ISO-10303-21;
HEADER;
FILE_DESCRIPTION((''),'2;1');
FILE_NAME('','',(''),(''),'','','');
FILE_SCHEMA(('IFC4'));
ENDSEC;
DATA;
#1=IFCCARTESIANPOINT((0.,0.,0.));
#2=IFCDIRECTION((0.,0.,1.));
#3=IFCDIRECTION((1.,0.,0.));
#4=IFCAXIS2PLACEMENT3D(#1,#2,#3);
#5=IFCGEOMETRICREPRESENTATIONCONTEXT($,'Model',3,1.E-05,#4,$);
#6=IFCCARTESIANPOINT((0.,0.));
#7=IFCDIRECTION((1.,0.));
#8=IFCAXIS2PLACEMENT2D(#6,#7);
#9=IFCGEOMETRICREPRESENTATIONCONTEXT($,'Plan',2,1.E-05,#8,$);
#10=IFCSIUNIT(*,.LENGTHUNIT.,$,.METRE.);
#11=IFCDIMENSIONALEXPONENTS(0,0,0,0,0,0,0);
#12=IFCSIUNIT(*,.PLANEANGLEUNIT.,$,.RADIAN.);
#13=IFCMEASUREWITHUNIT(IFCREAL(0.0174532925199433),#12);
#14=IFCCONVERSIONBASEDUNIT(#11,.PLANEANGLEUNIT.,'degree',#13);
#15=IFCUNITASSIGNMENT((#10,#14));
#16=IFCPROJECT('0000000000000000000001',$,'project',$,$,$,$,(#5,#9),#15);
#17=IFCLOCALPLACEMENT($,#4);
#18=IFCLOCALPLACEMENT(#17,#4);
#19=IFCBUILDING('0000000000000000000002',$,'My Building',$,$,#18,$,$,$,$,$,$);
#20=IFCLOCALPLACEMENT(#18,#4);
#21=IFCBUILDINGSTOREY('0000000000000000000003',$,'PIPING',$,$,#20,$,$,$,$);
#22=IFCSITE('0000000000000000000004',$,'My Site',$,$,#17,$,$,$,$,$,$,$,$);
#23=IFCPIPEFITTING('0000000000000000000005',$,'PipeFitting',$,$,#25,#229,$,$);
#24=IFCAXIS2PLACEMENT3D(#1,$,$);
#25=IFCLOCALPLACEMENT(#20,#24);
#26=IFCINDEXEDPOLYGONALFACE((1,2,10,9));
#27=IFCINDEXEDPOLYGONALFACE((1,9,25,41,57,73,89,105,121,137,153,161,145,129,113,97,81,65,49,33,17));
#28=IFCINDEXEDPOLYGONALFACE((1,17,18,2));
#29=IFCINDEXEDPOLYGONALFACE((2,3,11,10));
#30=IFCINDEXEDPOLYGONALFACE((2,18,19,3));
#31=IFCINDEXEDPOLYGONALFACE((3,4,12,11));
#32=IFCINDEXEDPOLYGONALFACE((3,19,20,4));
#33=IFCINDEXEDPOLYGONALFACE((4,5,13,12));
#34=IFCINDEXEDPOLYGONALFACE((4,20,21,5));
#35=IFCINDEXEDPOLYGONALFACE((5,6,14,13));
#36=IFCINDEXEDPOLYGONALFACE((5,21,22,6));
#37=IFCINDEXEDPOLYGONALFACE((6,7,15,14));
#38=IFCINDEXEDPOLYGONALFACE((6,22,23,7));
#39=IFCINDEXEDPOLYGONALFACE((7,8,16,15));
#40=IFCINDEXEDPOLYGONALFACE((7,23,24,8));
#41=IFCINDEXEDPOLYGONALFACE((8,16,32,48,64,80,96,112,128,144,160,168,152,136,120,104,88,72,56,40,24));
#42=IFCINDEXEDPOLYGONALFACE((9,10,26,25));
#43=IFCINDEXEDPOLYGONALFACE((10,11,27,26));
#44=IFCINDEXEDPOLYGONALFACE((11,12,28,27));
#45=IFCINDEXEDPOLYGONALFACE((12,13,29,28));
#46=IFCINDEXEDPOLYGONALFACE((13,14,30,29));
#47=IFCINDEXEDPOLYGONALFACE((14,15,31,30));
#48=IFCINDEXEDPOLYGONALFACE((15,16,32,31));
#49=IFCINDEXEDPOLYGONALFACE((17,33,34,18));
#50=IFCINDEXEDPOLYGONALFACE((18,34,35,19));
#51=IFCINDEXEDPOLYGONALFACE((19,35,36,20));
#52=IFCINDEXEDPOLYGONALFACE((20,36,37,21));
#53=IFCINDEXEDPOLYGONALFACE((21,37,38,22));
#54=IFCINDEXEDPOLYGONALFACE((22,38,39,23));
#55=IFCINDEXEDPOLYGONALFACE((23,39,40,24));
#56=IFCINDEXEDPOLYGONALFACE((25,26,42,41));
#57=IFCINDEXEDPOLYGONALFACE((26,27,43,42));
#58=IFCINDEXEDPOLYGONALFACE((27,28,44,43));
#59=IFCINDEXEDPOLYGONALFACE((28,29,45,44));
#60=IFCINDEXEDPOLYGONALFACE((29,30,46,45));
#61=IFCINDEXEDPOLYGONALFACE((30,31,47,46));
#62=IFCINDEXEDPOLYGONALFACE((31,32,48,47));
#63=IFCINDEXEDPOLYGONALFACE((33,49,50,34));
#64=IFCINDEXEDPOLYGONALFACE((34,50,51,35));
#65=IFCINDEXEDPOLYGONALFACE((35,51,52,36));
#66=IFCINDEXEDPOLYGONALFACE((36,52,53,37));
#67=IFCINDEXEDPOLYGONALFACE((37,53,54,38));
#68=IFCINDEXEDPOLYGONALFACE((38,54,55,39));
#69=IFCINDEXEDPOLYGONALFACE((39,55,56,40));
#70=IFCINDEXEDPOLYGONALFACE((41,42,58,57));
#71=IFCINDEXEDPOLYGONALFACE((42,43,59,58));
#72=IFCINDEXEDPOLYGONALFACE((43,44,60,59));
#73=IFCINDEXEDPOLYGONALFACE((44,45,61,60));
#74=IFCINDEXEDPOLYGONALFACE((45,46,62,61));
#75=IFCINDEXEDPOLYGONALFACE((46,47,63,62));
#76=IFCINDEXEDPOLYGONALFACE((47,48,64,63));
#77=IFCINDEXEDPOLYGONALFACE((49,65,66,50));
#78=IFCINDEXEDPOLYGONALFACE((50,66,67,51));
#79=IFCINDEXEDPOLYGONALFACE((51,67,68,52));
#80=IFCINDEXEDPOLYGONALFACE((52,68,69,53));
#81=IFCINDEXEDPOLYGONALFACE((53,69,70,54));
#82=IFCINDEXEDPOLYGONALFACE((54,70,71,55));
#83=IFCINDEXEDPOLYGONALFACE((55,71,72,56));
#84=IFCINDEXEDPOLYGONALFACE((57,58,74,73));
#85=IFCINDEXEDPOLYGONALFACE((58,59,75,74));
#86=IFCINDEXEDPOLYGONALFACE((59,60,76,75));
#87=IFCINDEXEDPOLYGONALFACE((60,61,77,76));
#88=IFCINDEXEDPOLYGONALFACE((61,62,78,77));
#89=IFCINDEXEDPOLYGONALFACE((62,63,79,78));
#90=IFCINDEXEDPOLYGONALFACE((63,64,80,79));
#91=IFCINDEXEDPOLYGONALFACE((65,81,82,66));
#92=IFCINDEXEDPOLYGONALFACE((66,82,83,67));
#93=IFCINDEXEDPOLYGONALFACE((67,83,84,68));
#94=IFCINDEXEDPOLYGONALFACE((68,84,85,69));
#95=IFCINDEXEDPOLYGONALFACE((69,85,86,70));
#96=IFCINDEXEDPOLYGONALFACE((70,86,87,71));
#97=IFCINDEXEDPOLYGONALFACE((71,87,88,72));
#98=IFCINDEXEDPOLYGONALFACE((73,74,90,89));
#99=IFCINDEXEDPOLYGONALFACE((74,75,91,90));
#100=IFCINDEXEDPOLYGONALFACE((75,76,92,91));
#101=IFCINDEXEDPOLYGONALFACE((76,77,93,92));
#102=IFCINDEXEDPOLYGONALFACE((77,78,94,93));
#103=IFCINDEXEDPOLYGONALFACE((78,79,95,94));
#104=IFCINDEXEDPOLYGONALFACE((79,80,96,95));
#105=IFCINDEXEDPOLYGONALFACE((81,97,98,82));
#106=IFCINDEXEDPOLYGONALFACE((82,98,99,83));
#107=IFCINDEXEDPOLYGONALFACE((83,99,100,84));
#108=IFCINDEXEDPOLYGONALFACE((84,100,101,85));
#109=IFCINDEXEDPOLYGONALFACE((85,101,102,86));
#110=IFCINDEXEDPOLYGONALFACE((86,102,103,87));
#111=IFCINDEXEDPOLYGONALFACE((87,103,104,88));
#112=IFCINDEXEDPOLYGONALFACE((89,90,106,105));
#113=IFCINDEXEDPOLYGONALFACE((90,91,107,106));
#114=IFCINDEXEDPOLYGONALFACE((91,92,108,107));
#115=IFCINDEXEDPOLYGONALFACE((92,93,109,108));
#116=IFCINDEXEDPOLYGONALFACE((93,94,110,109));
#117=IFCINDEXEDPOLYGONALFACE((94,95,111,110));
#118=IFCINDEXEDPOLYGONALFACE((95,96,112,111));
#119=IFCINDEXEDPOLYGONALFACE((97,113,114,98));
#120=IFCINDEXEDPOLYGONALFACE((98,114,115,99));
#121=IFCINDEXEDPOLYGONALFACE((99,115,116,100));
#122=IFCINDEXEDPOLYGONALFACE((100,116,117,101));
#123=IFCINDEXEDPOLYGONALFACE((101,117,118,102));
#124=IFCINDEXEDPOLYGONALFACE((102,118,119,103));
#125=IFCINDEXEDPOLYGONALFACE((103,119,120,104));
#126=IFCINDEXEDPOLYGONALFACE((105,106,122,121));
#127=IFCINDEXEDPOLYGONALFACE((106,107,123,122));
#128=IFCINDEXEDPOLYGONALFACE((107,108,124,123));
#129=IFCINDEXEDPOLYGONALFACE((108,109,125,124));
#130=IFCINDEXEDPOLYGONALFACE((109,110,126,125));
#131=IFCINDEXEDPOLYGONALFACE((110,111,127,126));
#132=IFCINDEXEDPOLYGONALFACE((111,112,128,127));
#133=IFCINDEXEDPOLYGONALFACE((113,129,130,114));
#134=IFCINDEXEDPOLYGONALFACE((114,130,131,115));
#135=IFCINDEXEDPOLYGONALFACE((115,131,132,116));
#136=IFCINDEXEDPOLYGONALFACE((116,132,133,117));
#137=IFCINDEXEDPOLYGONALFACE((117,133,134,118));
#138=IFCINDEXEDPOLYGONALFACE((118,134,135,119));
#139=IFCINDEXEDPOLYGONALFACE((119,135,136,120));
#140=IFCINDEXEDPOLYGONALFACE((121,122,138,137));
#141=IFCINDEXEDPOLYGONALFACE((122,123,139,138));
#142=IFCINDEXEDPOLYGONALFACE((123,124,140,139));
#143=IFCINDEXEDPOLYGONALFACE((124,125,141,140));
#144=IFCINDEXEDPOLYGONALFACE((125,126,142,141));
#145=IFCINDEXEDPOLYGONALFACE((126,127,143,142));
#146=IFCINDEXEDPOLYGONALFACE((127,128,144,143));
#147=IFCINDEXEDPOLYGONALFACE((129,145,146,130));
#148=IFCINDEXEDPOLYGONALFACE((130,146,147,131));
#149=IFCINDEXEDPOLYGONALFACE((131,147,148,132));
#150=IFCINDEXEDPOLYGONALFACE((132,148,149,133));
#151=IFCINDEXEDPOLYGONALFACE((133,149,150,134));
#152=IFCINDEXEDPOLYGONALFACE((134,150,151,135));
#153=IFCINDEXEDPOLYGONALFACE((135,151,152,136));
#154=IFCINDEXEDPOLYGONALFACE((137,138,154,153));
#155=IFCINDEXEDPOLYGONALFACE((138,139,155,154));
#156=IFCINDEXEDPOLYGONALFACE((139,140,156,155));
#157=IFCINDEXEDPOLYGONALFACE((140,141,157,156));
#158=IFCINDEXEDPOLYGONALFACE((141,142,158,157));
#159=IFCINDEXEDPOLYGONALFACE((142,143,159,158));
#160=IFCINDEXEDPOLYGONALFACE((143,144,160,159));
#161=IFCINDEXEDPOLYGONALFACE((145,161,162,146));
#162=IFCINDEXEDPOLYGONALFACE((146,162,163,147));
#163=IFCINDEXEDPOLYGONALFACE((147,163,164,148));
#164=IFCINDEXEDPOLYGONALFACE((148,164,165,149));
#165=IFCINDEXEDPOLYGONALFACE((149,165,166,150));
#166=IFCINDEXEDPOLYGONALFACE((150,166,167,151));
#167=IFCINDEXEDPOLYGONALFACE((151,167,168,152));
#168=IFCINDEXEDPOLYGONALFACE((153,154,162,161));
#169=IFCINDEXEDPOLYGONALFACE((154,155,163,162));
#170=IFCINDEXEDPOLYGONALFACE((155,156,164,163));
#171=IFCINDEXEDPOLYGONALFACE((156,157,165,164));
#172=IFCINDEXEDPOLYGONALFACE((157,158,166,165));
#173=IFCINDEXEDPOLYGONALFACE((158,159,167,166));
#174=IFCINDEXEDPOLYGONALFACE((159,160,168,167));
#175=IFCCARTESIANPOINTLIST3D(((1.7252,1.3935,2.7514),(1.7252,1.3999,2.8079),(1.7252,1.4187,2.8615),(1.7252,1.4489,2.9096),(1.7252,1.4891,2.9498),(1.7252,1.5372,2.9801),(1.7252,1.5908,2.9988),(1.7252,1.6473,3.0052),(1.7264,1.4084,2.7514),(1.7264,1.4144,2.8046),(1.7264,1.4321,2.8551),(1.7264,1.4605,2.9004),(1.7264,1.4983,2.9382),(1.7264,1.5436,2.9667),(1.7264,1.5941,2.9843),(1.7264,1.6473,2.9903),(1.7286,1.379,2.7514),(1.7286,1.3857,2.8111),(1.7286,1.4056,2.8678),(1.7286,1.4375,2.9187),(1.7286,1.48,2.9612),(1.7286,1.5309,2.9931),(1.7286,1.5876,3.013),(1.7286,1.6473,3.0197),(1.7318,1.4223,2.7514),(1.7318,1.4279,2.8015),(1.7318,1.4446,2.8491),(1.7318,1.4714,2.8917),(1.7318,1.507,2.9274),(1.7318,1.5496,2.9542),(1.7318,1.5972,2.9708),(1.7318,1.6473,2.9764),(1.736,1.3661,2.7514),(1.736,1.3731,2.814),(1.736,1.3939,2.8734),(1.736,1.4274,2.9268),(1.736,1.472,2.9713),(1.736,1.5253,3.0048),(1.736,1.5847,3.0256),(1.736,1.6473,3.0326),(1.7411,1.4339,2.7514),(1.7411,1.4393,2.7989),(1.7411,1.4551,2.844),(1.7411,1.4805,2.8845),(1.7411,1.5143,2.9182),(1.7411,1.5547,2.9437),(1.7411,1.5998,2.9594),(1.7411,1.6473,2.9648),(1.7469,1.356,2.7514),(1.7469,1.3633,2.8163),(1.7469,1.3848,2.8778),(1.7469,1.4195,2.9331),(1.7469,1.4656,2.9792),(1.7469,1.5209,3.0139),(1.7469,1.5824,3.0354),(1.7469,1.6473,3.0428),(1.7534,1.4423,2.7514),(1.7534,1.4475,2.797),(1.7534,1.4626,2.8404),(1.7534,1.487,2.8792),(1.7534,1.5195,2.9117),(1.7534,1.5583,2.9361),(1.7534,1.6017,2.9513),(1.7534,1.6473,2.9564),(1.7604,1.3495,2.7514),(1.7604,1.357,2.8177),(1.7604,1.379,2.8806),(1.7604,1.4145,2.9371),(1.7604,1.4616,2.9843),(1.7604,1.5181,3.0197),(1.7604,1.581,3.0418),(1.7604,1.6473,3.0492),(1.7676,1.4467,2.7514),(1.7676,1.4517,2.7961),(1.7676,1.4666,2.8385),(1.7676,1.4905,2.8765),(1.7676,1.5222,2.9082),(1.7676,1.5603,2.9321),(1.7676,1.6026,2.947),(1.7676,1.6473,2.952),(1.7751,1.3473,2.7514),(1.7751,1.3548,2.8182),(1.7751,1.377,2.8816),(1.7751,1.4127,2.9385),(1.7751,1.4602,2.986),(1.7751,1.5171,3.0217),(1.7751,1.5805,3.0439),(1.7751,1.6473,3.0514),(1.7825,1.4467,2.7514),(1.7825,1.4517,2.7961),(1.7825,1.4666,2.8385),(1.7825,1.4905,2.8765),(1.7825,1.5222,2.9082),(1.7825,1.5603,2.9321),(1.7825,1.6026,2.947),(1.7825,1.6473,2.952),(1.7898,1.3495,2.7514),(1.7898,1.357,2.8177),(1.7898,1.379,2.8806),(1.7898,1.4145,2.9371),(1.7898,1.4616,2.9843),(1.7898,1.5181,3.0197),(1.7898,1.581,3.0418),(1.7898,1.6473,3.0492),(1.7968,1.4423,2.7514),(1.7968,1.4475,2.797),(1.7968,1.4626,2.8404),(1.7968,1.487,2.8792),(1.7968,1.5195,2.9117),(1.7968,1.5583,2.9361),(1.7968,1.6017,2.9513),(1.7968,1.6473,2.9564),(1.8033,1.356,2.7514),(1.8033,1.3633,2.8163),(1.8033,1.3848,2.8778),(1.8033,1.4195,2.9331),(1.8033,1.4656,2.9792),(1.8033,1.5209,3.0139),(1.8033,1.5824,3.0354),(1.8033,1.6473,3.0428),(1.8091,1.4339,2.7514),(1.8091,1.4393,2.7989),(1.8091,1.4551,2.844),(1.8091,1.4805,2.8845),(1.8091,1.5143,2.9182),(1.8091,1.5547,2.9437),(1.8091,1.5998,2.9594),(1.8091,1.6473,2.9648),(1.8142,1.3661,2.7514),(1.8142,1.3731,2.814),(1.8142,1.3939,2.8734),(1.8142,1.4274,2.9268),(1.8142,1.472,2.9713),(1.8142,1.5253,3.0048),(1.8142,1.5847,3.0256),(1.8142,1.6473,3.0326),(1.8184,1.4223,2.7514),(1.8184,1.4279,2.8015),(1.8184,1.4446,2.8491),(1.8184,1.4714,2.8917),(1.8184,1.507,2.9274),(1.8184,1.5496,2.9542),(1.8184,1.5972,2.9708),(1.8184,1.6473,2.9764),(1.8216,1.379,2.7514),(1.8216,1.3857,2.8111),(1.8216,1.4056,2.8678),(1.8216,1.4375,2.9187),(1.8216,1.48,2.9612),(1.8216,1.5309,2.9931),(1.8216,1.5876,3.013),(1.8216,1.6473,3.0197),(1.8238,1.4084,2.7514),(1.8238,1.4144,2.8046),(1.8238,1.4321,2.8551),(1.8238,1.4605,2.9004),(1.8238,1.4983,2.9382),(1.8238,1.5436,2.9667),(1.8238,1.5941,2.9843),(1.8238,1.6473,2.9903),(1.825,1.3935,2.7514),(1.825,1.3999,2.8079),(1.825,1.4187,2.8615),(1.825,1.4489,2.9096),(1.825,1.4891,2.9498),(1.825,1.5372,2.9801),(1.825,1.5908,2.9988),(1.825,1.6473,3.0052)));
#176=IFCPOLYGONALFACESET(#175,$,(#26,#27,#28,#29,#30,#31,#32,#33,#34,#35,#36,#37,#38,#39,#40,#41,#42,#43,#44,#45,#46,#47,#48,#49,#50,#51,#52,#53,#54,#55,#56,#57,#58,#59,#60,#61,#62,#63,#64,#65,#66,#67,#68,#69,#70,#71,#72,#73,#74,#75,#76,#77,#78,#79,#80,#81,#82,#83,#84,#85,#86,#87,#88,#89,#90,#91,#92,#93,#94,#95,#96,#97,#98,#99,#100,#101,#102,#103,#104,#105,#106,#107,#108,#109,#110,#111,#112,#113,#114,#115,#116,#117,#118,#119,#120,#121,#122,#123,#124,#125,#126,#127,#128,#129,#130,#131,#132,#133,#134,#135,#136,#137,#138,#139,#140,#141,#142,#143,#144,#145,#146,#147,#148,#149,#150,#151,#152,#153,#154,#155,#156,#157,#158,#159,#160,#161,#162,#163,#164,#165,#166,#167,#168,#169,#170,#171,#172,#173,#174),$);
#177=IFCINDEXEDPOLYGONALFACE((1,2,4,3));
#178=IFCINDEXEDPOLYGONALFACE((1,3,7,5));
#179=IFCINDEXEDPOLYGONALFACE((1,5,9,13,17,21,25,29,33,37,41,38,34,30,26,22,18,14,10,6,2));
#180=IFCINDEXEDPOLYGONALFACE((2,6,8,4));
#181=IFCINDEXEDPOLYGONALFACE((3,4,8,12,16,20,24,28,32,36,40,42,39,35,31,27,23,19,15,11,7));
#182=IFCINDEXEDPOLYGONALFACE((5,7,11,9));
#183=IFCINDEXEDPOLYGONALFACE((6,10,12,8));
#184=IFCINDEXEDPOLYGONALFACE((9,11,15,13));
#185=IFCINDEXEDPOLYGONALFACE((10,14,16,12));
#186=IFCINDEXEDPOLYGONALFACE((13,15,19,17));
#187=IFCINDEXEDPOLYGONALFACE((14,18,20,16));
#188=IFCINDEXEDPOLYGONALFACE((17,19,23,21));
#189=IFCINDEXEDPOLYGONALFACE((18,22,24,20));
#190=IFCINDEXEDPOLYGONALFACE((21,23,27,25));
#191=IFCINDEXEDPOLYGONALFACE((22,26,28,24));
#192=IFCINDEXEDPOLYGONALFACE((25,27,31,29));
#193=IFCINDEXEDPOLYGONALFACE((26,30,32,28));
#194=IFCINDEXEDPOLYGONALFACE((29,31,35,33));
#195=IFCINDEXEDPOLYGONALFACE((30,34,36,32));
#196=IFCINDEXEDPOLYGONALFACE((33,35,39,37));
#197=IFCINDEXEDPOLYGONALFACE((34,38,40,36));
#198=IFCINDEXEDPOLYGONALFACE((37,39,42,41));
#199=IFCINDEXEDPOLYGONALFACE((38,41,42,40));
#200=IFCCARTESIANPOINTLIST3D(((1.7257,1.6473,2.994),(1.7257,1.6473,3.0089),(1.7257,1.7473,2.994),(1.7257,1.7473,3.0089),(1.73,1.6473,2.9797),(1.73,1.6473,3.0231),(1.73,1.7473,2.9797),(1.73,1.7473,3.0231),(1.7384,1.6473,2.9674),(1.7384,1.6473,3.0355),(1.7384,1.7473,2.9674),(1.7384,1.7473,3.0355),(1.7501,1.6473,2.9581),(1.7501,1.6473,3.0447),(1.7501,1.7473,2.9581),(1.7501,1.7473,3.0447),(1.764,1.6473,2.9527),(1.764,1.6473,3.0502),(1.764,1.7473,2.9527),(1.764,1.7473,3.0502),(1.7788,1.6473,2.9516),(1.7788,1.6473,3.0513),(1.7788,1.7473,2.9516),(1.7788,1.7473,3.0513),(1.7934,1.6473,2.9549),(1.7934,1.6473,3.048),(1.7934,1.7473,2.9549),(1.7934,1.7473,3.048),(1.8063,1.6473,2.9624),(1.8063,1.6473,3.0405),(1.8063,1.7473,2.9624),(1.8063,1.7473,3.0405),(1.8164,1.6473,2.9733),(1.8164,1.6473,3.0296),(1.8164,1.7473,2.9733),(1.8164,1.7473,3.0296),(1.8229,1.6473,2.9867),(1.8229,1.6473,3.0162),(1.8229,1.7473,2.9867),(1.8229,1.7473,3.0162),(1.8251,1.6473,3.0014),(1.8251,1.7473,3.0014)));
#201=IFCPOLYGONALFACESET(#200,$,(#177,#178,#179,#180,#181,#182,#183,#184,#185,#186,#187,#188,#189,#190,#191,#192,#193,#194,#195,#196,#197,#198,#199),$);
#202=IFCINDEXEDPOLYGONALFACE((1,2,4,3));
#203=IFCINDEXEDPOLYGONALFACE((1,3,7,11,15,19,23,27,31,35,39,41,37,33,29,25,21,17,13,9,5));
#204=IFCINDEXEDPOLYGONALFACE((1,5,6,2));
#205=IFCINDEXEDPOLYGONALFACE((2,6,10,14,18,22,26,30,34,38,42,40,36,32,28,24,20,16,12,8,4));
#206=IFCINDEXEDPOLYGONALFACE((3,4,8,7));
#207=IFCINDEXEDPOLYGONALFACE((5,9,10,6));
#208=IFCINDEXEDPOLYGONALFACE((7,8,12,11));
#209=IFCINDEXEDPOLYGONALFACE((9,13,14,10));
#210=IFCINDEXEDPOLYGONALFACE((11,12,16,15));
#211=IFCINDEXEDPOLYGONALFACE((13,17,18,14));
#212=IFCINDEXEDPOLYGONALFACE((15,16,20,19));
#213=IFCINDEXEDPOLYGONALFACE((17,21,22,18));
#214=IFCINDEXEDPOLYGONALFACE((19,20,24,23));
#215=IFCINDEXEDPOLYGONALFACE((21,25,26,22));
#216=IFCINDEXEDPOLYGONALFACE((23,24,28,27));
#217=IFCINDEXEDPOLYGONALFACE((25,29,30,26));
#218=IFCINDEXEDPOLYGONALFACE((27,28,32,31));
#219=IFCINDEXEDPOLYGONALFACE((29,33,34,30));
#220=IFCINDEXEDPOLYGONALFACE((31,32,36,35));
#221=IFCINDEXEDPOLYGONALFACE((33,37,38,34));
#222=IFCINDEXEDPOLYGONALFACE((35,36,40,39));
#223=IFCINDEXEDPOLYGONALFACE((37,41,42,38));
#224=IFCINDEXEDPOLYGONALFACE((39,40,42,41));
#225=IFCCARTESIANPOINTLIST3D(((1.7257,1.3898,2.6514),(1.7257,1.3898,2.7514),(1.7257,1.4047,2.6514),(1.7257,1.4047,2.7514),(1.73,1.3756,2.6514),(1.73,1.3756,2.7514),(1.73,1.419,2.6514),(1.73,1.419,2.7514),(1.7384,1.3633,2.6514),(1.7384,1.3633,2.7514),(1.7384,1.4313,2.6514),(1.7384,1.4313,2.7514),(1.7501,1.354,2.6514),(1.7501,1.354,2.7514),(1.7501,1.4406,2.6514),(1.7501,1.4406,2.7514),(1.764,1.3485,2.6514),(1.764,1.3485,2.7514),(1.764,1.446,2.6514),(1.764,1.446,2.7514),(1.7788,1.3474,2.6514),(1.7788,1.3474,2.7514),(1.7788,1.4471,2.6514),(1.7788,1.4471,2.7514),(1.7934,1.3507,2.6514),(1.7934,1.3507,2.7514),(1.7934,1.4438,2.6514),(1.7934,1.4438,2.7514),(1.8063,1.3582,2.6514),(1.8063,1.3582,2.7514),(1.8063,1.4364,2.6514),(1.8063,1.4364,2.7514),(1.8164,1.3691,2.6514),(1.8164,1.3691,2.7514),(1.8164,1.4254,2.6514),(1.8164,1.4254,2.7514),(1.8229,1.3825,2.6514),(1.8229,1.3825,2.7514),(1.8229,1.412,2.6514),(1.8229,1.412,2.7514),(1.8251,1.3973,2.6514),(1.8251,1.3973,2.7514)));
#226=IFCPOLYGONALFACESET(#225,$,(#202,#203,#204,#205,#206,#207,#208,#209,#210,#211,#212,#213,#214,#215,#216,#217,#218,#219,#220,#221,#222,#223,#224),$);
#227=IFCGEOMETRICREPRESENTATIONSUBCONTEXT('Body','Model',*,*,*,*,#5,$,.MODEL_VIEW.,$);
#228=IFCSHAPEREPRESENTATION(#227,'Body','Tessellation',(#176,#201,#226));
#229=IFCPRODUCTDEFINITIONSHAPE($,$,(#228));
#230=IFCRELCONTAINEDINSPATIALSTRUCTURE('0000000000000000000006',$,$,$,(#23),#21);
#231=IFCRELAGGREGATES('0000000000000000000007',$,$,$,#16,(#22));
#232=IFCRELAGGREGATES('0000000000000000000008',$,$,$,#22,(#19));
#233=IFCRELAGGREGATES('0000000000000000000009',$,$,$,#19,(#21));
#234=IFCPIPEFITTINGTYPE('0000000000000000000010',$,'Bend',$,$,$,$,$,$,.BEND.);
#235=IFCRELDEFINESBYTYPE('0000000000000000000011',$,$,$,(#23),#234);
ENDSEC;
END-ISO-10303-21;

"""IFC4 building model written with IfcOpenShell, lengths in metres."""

from ifc_helpers import new_model, entity, si_unit, converted_unit, frame, origin_with_axes, origin_2d_with_axis, place, context, subcontext, project, spatial, circle, extrude, source, transform, mapped, type_object, type_shapes, element, save


model = new_model("IFC4")

# Units and contexts
model_context = context("Model", 3, precision=1e-05, world=origin_with_axes())
plan_context = context("Plan", 2, precision=1e-05, world=origin_2d_with_axis())
body_context = subcontext(model_context, "Body", "Model", "MODEL_VIEW")
ifc_project = project(units=[si_unit("LENGTHUNIT", "METRE"), converted_unit("PLANEANGLEUNIT", "degree", entity("IfcReal", 0.0174532925199433), si_unit("PLANEANGLEUNIT", "RADIAN"), dimensions=[0, 0, 0, 0, 0, 0, 0])], contexts=[model_context, plan_context])

# Site, building, storey
site_placement = place(None, origin_with_axes())
site = spatial("IfcSite", under=ifc_project, at=site_placement, Name="My Site")
building_placement = place(site_placement, origin_with_axes())
building = spatial("IfcBuilding", under=site, at=building_placement, Name="My Building")
storey_placement = place(building_placement, origin_with_axes())
storey = spatial("IfcBuildingStorey", under=building, at=storey_placement, Name="PIPING")

# Pipe fitting
pipe_fitting_type_1 = type_object("IfcPipeFittingType", Name="Bend", PredefinedType="BEND")
shared_shape = source(origin_with_axes(), body_context, "Body", "SolidModel", [
    entity("IfcSweptDiskSolid", entity("IfcIndexedPolyCurve", entity("IfcCartesianPointList3D", [[0.0, 0.0, -0.1], [0.0, 0.0732, -0.2768], [0.0, 0.25, -0.35]]), [entity("IfcArcIndex", [1, 2, 3])]), 0.05),
    extrude(circle(Radius=0.05), origin_with_axes(), (0.0, 0.0, -1.0), 0.1),
    extrude(circle(Radius=0.05), frame((0.0, 0.25, -0.35), z_axis=(0.0, 1.0, 0.0), x_axis=(1.0, 0.0, 0.0)), (0.0, 0.0, 1.0), 0.1),
])
type_shapes(pipe_fitting_type_1, [shared_shape])
for number, where, z_axis, x_axis, name in (
    (1, (1.7751, 1.7473, 3.0014), (0.0, 1.0, 0.0), (1.0, 0.0, 0.0), "PipeFitting"),
):
    element("IfcPipeFitting", number, at=place(storey_placement, frame(where, z_axis=z_axis, x_axis=x_axis)), inside=storey, type_object=pipe_fitting_type_1, Name=name, context=body_context, shape_type="MappedRepresentation", body=[
        mapped(shared_shape, transform((0.0, 0.0, 0.0), x_axis=(1.0, 0.0, 0.0), y_axis=(0.0, 1.0, 0.0), z_axis=(0.0, 0.0, 1.0), scale=1.0)),
    ])

save(model, "model.ifc")
